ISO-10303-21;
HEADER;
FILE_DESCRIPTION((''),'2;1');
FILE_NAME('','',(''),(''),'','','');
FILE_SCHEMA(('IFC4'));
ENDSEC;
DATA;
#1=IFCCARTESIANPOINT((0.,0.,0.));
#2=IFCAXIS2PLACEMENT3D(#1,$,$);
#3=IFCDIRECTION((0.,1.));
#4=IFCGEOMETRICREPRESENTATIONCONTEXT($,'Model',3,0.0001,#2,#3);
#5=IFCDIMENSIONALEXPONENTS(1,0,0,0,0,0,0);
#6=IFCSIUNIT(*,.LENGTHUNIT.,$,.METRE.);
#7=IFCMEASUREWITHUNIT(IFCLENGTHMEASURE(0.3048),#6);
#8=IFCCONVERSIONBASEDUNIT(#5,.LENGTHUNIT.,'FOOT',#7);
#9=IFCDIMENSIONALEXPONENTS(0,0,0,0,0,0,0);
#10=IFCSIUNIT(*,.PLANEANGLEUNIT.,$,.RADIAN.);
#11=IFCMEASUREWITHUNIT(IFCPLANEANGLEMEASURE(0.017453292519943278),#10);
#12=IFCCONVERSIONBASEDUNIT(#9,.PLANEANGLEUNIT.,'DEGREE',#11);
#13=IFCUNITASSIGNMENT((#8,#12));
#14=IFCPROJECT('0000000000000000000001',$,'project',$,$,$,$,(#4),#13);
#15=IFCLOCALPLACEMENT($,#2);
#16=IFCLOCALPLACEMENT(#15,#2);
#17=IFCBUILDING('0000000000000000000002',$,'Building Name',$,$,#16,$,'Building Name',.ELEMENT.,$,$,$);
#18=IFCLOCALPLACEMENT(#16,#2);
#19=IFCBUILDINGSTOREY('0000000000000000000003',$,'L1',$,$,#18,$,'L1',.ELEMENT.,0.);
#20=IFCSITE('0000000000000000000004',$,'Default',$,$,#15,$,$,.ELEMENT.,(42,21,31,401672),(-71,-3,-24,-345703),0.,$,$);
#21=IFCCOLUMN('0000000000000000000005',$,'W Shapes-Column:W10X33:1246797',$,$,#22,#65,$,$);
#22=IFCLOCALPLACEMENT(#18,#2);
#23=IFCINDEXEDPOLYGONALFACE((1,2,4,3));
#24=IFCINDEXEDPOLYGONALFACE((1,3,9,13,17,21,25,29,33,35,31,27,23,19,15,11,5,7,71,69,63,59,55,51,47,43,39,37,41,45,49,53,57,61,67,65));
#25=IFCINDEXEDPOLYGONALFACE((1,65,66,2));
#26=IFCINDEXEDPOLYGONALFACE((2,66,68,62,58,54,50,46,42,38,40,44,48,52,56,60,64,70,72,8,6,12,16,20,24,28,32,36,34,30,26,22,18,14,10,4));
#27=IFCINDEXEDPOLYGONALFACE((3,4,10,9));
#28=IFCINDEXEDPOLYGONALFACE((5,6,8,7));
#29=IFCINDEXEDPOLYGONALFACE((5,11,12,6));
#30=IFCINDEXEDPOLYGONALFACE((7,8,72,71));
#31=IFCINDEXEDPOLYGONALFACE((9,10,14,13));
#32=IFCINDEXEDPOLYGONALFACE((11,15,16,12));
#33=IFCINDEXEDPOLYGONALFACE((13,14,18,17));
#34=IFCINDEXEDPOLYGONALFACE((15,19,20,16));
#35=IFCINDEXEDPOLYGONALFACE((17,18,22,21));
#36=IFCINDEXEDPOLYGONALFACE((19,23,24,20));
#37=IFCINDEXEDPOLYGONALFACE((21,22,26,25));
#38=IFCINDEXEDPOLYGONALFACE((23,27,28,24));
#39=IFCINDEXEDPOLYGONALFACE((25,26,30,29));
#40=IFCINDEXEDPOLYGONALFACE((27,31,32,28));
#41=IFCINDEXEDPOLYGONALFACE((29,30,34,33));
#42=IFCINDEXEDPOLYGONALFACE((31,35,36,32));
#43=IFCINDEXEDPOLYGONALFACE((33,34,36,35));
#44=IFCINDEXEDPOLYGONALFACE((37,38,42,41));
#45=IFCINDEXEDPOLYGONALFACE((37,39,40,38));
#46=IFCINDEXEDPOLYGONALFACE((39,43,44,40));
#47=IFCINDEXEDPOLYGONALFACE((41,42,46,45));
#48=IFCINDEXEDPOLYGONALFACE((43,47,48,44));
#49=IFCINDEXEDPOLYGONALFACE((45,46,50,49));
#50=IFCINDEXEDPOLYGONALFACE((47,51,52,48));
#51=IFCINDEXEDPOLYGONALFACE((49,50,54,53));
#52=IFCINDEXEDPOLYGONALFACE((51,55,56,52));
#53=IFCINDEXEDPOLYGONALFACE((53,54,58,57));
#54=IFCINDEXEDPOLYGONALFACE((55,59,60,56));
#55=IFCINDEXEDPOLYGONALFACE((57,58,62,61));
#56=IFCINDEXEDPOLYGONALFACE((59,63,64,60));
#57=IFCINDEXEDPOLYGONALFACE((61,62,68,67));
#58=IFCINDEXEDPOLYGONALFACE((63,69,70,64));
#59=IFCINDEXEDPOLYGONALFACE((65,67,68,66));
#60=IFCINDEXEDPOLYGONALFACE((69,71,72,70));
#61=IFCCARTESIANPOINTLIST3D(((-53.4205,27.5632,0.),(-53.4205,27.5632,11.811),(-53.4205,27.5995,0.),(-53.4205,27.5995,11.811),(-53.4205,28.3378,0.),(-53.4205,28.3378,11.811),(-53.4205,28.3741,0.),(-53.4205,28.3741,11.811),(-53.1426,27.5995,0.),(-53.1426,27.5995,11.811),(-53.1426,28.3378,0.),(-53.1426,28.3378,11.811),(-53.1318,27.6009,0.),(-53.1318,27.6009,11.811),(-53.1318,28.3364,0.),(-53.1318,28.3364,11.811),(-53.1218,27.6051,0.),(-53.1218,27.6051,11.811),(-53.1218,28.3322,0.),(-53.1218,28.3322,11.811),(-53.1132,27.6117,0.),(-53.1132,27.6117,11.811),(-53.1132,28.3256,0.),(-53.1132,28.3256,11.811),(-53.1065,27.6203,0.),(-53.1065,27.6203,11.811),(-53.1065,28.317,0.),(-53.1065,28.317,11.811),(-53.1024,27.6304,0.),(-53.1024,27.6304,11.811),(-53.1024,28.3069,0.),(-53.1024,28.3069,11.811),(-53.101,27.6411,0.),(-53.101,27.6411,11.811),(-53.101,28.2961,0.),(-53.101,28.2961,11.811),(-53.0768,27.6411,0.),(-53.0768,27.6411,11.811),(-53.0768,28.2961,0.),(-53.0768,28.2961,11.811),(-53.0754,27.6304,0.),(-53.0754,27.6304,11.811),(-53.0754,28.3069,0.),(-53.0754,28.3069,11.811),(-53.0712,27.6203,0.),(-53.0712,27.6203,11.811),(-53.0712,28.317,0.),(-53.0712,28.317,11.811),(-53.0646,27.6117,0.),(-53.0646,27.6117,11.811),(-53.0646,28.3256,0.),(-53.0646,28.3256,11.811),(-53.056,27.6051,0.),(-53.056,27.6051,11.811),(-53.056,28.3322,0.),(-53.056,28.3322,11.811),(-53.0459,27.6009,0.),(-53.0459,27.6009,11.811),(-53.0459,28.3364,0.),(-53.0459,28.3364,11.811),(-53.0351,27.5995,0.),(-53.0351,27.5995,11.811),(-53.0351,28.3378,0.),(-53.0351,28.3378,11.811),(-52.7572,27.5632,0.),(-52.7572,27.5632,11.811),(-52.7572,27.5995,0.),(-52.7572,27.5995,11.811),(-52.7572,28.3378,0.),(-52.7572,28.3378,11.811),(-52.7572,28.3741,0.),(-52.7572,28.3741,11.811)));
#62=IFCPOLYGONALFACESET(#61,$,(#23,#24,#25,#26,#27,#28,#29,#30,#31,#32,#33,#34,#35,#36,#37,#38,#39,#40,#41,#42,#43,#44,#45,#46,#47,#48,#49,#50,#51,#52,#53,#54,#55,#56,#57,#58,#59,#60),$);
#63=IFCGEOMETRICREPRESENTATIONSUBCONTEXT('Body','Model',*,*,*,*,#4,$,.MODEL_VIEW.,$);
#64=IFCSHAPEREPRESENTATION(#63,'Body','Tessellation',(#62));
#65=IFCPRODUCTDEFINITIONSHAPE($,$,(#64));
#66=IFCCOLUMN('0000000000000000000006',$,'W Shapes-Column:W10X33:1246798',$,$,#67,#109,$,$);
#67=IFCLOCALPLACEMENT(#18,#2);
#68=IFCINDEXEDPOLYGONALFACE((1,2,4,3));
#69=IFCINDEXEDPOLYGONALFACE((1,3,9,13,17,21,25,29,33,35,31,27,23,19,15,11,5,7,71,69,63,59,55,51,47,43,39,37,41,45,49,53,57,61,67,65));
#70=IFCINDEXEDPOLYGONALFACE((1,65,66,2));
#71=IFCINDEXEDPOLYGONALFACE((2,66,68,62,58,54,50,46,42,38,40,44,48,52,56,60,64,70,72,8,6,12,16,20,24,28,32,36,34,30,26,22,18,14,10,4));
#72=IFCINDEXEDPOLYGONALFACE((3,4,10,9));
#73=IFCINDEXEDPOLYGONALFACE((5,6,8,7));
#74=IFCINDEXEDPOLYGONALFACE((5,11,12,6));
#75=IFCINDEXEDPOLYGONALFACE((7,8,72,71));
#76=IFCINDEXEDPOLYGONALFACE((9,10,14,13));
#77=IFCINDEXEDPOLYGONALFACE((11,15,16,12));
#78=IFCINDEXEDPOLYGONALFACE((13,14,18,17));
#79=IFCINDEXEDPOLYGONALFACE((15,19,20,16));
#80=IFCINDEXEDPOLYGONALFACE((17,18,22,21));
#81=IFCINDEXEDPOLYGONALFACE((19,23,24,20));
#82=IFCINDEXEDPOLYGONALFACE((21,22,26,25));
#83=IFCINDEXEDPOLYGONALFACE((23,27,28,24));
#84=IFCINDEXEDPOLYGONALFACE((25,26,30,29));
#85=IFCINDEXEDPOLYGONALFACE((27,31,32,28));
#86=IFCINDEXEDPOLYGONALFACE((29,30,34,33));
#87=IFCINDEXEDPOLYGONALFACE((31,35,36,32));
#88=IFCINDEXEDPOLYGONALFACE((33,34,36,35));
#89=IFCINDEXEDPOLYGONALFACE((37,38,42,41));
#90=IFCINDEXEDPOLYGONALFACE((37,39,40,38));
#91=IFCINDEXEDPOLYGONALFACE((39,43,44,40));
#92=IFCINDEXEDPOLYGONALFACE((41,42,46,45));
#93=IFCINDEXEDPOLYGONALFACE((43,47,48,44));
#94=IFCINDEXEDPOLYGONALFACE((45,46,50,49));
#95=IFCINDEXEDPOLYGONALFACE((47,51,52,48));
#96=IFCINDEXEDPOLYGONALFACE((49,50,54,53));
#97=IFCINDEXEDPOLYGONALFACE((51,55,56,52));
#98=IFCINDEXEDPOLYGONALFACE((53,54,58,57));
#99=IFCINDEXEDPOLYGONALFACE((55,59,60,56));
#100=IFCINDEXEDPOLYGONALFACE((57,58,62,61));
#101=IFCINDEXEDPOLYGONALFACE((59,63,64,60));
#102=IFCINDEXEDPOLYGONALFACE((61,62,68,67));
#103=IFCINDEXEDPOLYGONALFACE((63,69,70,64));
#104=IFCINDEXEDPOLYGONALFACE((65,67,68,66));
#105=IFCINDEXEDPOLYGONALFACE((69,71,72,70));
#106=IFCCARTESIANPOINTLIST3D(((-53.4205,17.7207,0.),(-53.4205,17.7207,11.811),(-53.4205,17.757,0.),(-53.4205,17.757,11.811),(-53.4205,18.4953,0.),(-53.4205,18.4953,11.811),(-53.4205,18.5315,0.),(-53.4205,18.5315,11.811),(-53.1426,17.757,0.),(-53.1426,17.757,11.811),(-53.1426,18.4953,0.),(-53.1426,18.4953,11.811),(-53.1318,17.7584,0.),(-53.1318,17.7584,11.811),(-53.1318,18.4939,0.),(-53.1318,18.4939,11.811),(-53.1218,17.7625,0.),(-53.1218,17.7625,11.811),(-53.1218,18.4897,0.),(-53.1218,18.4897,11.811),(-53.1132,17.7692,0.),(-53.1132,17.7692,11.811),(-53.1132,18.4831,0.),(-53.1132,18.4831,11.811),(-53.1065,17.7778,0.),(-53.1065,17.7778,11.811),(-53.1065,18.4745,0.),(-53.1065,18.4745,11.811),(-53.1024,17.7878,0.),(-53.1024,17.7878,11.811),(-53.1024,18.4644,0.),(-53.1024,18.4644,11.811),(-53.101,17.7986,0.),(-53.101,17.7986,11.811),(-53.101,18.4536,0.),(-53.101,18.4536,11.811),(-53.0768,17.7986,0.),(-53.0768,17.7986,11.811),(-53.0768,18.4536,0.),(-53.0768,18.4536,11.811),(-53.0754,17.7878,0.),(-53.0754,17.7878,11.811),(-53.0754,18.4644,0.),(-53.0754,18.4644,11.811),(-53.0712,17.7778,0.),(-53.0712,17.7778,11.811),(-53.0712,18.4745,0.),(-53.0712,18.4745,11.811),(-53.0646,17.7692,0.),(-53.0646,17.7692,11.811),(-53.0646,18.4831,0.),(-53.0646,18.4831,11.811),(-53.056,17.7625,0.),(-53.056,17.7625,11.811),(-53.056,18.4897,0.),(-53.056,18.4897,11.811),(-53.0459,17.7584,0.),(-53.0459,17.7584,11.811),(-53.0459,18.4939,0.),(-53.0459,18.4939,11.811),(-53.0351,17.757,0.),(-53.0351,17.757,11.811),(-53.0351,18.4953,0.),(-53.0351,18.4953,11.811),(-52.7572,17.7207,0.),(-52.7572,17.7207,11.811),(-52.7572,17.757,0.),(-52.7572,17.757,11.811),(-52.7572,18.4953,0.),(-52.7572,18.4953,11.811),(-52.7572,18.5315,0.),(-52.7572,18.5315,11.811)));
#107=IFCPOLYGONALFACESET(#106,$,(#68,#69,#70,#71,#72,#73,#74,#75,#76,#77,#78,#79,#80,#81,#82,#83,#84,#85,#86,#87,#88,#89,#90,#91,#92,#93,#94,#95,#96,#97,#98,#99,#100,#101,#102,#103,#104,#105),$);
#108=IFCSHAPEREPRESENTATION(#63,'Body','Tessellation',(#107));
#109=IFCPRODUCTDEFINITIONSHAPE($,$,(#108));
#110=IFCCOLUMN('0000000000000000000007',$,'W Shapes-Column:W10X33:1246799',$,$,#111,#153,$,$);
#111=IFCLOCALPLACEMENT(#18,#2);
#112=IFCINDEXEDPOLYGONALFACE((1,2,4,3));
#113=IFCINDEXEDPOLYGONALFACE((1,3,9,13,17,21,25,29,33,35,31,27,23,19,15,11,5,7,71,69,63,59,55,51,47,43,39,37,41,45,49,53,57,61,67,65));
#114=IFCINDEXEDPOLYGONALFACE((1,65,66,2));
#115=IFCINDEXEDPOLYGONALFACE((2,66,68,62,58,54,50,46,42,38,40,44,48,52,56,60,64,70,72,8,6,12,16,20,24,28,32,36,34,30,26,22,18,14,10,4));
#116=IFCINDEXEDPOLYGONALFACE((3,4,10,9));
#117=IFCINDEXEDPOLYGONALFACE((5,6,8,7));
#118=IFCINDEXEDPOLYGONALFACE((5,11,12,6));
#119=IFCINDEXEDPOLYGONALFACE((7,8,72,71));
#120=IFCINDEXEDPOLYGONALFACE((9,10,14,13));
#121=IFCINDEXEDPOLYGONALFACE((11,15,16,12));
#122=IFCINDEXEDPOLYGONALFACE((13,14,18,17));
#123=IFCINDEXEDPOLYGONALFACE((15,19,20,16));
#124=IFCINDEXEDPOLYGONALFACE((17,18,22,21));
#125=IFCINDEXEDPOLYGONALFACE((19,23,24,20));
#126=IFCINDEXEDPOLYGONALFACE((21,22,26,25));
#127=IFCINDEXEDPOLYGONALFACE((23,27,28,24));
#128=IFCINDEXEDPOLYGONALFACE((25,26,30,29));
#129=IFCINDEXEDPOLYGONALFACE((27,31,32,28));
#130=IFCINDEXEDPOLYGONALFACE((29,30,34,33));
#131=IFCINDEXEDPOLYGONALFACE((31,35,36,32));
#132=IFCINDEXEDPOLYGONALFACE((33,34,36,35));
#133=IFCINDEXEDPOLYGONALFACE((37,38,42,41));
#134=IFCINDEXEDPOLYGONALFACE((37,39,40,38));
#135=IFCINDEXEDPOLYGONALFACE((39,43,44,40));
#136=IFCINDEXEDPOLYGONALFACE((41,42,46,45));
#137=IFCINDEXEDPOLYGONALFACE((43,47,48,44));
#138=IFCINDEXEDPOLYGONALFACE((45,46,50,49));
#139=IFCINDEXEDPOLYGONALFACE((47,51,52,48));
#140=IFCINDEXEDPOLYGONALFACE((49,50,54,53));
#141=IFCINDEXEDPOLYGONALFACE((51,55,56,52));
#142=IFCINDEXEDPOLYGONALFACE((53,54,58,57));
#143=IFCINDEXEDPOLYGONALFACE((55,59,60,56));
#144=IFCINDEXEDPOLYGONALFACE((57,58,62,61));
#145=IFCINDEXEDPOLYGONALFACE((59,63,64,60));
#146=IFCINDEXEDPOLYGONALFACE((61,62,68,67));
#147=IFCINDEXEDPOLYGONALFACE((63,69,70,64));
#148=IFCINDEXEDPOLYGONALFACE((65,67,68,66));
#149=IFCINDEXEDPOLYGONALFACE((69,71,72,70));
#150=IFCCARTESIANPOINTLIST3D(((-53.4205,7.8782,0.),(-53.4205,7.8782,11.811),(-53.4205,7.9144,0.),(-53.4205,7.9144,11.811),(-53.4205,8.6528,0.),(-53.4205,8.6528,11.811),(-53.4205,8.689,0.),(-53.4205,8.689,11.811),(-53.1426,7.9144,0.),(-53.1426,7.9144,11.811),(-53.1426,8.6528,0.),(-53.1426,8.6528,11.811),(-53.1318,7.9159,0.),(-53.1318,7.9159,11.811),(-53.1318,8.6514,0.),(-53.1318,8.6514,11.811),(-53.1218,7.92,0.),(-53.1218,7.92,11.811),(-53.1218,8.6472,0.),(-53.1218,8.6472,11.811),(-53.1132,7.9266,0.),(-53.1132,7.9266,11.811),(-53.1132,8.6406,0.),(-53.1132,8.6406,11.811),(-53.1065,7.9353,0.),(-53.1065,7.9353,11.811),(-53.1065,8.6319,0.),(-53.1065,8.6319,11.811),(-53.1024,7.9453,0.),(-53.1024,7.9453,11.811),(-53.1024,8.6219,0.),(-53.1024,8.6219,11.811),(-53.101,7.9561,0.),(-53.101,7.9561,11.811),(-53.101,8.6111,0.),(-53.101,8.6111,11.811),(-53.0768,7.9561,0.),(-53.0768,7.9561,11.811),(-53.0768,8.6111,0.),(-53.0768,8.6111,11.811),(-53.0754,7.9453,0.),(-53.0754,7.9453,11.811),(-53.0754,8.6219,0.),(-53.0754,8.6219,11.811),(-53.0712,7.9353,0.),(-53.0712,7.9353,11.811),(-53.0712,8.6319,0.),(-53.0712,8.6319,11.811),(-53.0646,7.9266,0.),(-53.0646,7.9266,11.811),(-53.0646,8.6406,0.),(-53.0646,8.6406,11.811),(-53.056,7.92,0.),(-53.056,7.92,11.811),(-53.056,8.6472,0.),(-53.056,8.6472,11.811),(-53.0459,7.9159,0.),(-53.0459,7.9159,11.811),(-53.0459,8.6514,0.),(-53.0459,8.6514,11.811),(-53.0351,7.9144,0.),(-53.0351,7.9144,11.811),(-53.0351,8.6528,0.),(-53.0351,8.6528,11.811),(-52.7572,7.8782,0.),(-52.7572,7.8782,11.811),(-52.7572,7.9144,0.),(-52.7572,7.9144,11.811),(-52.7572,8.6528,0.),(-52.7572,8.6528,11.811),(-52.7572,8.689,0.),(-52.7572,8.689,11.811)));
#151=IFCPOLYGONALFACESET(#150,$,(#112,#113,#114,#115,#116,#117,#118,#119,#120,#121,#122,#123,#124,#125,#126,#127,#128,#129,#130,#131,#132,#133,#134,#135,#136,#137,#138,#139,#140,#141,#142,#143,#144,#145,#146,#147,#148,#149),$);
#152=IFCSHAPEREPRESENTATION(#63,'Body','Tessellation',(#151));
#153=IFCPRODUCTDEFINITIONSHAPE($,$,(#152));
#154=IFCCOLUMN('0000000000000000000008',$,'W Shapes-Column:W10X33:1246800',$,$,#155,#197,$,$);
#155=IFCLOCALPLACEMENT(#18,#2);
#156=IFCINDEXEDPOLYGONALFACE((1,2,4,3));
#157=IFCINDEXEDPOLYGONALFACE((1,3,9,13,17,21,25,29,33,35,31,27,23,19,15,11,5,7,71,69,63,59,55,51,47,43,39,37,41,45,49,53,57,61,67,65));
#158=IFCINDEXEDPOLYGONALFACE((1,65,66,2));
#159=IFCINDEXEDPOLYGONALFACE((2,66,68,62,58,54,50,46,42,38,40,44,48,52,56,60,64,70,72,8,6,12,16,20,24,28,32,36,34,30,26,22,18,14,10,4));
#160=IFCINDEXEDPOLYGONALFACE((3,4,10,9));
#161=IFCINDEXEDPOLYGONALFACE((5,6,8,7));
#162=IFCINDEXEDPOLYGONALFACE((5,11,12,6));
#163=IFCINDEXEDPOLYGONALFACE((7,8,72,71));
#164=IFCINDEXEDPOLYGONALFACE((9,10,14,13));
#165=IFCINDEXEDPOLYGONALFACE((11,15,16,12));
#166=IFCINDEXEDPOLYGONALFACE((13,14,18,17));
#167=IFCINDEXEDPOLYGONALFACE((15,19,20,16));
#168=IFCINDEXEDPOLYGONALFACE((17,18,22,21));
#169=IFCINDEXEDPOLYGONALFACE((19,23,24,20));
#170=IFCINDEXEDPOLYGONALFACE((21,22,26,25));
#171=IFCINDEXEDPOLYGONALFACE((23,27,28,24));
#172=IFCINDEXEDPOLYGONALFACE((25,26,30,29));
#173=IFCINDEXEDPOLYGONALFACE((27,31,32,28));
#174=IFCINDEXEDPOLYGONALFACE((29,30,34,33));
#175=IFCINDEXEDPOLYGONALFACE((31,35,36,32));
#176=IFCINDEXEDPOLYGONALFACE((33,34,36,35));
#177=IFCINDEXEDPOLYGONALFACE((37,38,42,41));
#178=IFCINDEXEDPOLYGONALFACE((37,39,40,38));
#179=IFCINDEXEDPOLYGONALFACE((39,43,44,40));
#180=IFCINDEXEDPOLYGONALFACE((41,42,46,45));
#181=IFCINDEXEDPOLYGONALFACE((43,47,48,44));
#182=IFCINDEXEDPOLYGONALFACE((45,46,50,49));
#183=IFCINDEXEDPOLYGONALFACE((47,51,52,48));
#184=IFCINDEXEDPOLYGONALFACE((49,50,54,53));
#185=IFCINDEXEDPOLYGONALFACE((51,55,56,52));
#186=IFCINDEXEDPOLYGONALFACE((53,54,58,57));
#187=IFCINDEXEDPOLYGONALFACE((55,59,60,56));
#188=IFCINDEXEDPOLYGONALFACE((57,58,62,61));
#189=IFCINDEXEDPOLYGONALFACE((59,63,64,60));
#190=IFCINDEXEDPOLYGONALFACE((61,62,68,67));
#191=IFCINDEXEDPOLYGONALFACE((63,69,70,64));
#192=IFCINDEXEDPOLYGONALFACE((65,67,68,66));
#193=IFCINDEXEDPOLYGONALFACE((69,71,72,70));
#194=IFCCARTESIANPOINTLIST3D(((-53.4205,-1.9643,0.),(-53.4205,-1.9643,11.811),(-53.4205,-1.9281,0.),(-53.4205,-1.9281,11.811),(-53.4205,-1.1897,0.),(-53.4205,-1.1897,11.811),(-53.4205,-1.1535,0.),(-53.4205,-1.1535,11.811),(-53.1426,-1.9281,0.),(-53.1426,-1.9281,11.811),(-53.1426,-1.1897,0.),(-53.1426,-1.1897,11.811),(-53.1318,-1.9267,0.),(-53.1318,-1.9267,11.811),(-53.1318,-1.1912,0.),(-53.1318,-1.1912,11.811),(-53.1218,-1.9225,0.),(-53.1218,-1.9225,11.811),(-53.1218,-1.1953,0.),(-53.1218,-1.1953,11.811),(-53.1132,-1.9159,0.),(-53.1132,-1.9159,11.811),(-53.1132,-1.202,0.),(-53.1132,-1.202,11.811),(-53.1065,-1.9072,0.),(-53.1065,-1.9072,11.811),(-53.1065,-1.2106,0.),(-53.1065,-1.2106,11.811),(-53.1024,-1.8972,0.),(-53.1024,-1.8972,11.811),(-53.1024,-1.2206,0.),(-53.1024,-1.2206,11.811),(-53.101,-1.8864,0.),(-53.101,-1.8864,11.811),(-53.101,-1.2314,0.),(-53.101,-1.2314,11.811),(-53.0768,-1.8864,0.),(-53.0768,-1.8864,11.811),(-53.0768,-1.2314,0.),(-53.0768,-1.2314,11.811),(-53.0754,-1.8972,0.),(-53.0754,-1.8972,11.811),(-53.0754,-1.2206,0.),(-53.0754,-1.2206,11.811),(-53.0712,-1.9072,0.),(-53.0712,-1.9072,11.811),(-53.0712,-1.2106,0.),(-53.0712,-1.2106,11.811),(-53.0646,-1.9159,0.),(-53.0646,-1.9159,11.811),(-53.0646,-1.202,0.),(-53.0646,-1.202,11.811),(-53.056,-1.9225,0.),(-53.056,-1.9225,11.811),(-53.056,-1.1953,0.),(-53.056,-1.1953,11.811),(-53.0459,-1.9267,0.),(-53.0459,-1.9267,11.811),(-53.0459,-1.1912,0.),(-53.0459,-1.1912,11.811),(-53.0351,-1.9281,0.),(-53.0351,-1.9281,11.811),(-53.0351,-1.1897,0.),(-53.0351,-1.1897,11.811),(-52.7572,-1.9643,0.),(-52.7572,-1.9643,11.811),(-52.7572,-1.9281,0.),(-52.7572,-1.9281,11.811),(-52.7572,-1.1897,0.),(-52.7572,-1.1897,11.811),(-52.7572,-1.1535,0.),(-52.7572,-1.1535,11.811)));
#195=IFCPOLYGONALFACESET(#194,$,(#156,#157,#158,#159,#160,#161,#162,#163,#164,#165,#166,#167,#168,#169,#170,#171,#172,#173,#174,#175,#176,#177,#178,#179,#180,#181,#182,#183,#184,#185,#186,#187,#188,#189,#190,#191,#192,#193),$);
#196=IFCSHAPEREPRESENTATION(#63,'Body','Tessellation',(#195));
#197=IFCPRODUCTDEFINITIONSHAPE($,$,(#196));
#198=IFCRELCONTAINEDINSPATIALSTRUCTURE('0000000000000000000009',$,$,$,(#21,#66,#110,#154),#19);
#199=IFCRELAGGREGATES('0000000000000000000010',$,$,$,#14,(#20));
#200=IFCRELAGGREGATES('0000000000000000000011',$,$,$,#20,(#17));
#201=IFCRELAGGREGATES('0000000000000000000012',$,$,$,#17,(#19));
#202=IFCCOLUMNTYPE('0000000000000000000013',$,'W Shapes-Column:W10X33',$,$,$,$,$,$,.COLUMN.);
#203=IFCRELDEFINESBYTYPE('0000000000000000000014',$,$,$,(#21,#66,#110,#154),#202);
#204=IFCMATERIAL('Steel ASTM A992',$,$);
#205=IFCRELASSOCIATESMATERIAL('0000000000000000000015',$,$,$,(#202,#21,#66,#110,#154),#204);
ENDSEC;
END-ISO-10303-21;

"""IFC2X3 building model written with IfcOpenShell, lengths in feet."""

from ifc_helpers import new_model, entity, si_unit, converted_unit, direction, frame, frame_2d, origin, place, context, subcontext, project, spatial, i_section, extrude, source, transform, mapped, material, type_object, type_shapes, element, save


model = new_model("IFC2X3")

# Units and contexts
model_context = context("Model", 3, precision=0.0001, world=origin(), true_north=direction((0.0, 1.0)))
body_context = subcontext(model_context, "Body", "Model", "MODEL_VIEW")
ifc_project = project(units=[converted_unit("LENGTHUNIT", "FOOT", entity("IfcLengthMeasure", 0.3048), si_unit("LENGTHUNIT", "METRE"), dimensions=[1, 0, 0, 0, 0, 0, 0]), converted_unit("PLANEANGLEUNIT", "DEGREE", entity("IfcPlaneAngleMeasure", 0.017453292519943278), si_unit("PLANEANGLEUNIT", "RADIAN"), dimensions=[0, 0, 0, 0, 0, 0, 0])], contexts=[model_context])

# Site, building, storey
site_placement = place(None, origin())
site = spatial("IfcSite", under=ifc_project, at=site_placement, Name="Default", CompositionType="ELEMENT", RefLatitude=(42, 21, 31, 401672), RefLongitude=(-71, -3, -24, -345703), RefElevation=0.0)
building_placement = place(site_placement, origin())
building = spatial("IfcBuilding", under=site, at=building_placement, Name="Building Name", LongName="Building Name", CompositionType="ELEMENT")
storey_placement = place(building_placement, origin())
storey = spatial("IfcBuildingStorey", under=building, at=storey_placement, Name="L1", LongName="L1", CompositionType="ELEMENT", Elevation=0.0)

# Columns
ifc_material = material(Name="Steel ASTM A992")
column_type = type_object("IfcColumnType", Name="W Shapes-Column:W10X33", PredefinedType="COLUMN", material=ifc_material)
shared_shape = source(origin(), body_context, "Body", "SweptSolid", [
    extrude(i_section(OverallWidth=0.6633, OverallDepth=0.8108, WebThickness=0.0242, FlangeThickness=0.0362, FilletRadius=0.0417, at=frame_2d((0.0, 0.0), x_axis=(1.0, 0.0))), frame((0.0, 0.0, 0.0), z_axis=(0.0, 0.0, 1.0), x_axis=(-1.0, 0.0, 0.0)), (0.0, 0.0, 1.0), 11.811),
])
type_shapes(column_type, [shared_shape])
for number, where, name in (
    (1, (-53.0889, 27.9686, 0.0), "W Shapes-Column:W10X33:1246797"),
    (2, (-53.0889, 18.1261, 0.0), "W Shapes-Column:W10X33:1246798"),
    (3, (-53.0889, 8.2836, 0.0), "W Shapes-Column:W10X33:1246799"),
    (4, (-53.0889, -1.5589, 0.0), "W Shapes-Column:W10X33:1246800"),
):
    element("IfcColumn", number, at=place(storey_placement, frame(where)), inside=storey, type_object=column_type, material=ifc_material, Name=name, context=body_context, shape_type="MappedRepresentation", body=[
        mapped(shared_shape, transform((0.0, 0.0, 0.0), scale=1.0)),
    ])

save(model, "model.ifc")
